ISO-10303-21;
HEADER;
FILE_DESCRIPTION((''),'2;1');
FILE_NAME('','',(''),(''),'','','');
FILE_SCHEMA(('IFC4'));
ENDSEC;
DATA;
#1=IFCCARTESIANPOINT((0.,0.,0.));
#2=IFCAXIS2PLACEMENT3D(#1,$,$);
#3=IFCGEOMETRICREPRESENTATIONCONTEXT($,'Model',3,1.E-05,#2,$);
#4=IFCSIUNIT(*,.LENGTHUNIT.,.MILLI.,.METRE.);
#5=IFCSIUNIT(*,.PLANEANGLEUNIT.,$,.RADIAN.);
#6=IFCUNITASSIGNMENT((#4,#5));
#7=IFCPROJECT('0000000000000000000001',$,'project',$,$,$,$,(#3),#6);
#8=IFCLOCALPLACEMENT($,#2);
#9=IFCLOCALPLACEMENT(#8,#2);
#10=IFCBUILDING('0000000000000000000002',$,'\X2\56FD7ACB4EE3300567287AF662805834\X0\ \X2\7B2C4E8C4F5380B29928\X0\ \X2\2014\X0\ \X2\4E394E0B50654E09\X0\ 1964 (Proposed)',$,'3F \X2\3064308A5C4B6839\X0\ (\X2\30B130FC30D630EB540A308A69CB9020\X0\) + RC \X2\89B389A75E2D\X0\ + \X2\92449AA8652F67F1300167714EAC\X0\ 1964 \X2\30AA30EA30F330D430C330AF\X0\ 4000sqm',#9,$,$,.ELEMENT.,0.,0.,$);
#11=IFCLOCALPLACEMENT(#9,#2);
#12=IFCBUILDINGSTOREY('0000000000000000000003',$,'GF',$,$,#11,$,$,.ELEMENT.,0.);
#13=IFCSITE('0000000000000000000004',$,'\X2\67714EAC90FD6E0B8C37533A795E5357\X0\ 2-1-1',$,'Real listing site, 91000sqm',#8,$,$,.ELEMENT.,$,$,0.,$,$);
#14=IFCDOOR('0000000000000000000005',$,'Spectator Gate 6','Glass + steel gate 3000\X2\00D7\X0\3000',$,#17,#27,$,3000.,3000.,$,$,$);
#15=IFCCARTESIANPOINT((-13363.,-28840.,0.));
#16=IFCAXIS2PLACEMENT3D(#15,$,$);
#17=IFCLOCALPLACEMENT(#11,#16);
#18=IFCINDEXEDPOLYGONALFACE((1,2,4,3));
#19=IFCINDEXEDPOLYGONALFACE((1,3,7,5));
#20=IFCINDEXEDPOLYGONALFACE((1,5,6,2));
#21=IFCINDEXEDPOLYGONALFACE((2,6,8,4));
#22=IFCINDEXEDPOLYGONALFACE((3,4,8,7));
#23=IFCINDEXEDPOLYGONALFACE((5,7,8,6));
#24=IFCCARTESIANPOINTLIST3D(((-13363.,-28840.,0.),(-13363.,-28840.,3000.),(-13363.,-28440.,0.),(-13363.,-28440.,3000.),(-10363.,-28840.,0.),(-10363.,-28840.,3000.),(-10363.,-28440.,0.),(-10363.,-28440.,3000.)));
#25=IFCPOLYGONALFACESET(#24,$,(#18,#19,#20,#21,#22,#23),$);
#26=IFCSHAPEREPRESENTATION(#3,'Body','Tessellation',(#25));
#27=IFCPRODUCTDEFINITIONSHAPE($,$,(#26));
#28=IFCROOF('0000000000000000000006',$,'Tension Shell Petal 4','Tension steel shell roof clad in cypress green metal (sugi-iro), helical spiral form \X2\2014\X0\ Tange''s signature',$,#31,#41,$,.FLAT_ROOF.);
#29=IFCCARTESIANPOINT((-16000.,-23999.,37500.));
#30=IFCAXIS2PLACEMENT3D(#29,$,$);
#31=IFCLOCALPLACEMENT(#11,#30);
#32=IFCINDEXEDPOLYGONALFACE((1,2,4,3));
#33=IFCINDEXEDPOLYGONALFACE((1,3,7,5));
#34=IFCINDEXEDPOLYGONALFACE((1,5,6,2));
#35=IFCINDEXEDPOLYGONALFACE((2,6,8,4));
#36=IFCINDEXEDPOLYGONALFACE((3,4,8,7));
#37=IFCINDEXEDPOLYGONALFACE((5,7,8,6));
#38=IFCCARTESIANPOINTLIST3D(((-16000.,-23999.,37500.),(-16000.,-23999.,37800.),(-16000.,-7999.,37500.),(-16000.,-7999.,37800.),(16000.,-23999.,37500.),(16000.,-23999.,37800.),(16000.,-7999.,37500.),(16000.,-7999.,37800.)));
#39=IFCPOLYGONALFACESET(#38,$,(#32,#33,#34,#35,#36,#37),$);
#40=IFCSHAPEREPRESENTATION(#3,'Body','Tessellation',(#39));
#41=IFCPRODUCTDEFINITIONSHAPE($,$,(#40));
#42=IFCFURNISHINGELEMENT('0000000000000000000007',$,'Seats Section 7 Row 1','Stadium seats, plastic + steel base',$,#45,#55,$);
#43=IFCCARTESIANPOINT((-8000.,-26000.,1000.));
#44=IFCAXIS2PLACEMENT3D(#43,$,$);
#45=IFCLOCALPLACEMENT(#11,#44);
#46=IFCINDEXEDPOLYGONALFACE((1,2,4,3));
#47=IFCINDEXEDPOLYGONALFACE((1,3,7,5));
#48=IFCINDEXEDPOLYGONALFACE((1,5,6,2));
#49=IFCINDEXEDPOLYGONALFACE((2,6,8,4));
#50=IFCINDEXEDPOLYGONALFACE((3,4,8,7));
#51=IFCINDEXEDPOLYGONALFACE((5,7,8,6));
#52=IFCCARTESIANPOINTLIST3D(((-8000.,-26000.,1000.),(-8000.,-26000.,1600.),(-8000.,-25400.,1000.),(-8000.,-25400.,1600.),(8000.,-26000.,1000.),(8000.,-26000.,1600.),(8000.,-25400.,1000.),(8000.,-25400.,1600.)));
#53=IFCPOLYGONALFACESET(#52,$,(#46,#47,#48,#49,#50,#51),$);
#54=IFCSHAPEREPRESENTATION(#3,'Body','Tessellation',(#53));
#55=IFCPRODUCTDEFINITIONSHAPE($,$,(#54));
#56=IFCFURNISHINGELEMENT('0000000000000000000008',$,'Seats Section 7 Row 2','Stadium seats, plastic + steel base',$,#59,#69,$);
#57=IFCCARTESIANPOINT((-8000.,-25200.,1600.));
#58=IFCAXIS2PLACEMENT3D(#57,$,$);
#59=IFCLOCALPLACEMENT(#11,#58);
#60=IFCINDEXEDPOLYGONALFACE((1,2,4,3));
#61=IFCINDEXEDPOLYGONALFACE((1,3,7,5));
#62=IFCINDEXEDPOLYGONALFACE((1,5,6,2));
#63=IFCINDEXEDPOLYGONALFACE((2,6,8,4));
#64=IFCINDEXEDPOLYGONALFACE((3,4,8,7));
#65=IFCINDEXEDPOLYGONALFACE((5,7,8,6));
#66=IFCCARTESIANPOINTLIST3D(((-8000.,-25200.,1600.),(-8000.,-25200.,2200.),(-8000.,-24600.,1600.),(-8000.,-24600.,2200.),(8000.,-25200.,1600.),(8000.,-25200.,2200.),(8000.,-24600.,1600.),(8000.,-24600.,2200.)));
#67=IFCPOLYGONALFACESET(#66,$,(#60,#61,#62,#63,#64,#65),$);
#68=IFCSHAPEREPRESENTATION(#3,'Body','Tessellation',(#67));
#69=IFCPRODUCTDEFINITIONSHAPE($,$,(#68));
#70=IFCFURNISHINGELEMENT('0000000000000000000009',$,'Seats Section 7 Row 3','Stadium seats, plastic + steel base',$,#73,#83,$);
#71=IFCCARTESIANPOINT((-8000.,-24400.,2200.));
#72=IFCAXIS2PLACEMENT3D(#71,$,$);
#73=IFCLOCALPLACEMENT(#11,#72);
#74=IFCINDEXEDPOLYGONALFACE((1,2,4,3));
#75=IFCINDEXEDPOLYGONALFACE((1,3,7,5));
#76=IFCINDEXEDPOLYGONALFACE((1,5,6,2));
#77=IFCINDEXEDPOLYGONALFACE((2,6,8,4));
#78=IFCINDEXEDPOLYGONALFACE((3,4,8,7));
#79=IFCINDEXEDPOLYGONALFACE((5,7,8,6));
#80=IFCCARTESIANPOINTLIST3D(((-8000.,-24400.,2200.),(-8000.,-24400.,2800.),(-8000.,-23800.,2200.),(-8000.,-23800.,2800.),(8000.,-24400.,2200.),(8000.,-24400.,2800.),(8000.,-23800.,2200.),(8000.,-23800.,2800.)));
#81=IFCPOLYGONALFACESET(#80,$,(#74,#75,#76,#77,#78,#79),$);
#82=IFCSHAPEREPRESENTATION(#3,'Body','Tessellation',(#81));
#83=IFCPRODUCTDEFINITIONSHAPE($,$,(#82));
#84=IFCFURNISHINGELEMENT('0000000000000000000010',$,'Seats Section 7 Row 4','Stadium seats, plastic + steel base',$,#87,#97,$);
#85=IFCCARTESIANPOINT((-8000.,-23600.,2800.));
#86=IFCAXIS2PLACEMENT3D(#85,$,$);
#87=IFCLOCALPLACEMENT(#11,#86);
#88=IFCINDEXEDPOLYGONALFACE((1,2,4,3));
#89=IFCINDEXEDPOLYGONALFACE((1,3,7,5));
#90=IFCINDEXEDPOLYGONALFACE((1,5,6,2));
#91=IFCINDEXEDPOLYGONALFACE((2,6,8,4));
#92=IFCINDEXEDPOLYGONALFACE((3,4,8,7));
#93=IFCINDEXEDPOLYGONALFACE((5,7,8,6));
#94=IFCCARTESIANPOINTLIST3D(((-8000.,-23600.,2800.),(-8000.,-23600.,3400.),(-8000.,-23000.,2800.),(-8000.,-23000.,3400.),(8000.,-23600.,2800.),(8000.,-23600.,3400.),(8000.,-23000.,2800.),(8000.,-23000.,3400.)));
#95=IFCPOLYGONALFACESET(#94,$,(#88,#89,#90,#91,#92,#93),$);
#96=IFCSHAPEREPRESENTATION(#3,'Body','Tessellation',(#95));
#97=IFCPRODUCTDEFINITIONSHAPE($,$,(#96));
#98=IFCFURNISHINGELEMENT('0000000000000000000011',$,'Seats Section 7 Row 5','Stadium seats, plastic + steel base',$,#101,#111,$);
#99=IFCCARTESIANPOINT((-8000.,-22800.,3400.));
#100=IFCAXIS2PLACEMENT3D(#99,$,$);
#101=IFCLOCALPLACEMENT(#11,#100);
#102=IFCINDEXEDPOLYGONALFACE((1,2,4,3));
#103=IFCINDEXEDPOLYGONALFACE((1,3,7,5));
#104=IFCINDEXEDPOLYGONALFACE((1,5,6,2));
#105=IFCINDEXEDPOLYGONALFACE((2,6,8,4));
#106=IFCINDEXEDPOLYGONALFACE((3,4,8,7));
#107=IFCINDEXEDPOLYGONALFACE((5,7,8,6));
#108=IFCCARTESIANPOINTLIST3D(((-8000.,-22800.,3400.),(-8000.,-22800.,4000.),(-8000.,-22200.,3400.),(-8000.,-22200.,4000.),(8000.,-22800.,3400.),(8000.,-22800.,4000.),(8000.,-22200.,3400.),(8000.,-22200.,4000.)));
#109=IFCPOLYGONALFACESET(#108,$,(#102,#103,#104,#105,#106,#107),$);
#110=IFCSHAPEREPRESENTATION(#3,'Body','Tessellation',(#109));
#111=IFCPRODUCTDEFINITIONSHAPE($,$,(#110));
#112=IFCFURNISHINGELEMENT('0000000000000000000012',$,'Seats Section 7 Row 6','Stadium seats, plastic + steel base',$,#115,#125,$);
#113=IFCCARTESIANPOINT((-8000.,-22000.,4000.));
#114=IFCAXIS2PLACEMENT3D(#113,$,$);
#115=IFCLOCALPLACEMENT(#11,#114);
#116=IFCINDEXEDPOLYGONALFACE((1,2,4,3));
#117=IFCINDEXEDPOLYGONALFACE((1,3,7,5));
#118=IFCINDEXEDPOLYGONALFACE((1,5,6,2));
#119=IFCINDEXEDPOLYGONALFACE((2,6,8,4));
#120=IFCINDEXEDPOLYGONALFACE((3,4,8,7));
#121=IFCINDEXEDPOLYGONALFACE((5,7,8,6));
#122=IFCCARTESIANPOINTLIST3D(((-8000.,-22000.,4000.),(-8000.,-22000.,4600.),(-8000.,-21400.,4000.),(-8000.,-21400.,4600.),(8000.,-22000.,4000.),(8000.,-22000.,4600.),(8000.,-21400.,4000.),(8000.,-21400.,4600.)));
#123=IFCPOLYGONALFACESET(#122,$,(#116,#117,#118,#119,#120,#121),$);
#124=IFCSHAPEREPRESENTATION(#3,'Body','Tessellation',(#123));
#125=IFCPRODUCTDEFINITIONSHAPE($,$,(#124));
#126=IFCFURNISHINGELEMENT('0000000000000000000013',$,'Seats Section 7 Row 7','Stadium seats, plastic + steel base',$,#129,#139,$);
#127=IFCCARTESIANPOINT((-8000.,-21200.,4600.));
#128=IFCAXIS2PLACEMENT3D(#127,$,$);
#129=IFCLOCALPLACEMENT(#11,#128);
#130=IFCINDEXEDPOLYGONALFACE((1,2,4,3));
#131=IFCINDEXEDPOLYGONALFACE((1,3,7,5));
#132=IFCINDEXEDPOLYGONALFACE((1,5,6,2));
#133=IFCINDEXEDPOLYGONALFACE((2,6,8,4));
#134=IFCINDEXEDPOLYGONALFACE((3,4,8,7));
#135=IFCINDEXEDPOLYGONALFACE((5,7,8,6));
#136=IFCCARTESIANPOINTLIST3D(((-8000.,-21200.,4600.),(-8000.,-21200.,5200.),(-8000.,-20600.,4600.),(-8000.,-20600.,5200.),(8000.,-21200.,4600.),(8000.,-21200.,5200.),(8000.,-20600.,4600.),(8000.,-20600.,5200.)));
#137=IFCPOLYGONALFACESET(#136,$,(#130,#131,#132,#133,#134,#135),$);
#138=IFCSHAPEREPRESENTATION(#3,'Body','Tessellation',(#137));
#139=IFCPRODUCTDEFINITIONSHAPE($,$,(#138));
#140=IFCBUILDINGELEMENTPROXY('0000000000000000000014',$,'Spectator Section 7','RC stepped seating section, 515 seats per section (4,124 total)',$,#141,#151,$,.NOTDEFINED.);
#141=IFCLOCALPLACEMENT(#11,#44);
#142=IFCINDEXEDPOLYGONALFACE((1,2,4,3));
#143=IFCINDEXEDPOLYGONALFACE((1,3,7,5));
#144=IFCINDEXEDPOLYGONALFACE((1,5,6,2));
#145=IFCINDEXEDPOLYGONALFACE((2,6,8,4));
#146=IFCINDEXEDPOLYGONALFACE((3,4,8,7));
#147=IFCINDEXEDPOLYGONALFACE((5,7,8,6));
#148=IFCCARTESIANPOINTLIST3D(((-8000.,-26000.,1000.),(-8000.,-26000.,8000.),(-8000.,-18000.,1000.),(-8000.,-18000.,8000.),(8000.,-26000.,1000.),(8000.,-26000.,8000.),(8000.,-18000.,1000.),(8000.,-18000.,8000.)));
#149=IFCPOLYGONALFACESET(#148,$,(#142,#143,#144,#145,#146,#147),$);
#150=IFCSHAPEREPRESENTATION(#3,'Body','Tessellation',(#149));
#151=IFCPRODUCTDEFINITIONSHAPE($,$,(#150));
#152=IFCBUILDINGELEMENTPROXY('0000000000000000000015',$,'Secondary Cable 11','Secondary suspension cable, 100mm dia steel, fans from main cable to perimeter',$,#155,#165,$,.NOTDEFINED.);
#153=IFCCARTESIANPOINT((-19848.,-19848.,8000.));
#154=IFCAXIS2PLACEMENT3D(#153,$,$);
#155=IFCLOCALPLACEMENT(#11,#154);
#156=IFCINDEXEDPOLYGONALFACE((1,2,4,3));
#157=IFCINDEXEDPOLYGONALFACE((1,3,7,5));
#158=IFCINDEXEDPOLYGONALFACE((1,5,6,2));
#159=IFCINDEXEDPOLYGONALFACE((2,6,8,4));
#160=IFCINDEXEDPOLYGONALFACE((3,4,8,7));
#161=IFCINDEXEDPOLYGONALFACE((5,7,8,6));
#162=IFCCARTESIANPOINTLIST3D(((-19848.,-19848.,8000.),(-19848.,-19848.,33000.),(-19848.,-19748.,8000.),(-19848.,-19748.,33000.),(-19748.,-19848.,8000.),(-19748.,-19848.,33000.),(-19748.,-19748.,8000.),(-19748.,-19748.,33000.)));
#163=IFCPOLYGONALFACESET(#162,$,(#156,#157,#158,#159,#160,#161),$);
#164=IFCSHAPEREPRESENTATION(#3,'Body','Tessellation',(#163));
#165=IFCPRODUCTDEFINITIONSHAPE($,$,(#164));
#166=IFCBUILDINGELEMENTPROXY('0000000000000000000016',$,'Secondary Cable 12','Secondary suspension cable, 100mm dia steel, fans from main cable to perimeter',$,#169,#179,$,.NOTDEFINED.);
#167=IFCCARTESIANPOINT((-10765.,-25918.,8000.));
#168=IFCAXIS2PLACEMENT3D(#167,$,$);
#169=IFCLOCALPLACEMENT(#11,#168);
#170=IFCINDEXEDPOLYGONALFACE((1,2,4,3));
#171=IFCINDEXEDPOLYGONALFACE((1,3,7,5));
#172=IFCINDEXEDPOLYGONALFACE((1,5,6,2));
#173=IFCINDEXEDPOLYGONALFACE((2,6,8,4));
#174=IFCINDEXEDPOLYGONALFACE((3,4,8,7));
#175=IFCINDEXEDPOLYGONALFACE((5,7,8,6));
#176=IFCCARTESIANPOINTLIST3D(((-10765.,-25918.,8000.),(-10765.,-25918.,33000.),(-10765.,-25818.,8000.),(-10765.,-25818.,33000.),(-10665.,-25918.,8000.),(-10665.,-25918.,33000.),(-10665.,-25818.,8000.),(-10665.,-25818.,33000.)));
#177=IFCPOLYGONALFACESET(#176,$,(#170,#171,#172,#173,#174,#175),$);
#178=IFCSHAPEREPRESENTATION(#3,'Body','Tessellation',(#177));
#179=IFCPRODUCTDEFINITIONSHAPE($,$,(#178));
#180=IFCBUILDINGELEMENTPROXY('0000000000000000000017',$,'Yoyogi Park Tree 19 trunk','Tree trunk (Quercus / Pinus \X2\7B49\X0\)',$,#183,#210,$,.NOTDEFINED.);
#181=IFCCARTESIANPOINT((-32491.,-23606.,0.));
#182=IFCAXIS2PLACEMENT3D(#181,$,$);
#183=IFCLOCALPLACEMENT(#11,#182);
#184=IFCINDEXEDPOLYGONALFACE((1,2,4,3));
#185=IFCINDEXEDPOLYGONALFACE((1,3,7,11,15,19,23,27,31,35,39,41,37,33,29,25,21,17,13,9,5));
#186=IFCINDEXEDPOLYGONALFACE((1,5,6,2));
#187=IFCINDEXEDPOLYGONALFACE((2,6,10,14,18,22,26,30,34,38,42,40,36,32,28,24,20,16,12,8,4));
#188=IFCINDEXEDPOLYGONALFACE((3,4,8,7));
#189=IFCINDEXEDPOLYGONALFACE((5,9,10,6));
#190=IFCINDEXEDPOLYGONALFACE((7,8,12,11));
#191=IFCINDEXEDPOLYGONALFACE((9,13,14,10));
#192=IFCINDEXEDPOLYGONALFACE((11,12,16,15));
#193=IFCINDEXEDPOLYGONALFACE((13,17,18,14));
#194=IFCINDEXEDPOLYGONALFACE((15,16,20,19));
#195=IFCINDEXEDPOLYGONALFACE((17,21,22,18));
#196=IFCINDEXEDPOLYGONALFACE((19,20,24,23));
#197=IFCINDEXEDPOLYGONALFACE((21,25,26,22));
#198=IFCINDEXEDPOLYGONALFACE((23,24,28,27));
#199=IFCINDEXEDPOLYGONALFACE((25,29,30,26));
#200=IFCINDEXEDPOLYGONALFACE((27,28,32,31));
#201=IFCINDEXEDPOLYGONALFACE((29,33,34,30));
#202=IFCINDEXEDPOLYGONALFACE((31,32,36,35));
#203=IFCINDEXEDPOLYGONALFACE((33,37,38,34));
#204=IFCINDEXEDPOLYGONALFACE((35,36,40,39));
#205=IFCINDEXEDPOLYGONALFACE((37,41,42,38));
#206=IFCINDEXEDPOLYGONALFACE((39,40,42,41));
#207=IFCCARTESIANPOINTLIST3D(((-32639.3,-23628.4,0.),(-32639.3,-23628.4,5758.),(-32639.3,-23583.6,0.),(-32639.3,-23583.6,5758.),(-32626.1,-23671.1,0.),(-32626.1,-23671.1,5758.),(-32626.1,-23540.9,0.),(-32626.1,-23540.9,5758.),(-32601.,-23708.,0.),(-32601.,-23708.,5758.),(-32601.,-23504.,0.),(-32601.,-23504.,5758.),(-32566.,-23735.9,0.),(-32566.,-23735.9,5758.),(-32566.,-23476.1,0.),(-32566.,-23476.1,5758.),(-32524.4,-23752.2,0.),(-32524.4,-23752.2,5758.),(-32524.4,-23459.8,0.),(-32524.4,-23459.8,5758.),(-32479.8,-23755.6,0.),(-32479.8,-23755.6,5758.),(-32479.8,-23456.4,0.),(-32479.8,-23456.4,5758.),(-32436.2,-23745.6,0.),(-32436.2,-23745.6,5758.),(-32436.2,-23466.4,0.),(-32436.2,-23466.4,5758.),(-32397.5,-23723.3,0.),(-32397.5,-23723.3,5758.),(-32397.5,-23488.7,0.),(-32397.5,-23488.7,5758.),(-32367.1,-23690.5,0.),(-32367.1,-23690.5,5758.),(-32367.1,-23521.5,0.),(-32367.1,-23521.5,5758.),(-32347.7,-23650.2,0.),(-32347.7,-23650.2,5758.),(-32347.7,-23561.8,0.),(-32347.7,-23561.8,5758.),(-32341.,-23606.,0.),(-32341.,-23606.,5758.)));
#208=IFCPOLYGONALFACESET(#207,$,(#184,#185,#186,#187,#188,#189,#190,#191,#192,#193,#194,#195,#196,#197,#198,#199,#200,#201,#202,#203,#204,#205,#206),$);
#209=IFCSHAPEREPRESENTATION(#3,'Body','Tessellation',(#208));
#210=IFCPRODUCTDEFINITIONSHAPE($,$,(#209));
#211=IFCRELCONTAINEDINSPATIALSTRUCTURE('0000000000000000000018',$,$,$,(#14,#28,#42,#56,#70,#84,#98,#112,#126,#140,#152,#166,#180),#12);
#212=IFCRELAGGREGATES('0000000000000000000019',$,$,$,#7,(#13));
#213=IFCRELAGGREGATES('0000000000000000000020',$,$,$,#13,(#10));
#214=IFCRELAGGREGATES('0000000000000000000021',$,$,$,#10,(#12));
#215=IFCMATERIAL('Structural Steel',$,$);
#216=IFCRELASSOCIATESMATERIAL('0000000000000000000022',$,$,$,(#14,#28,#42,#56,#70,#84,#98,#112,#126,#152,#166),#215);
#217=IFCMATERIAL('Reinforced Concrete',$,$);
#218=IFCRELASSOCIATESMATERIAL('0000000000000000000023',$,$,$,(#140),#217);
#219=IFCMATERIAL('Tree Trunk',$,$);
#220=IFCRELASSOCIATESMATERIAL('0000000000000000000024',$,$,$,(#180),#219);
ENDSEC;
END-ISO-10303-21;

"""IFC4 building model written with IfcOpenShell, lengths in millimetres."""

from ifc_helpers import new_model, si_unit, frame, frame_2d, origin, origin_2d, place, context, project, spatial, rectangle, circle, extrude, material, element, save


model = new_model("IFC4")

# Units and contexts
model_context = context("Model", 3, precision=1e-05, world=origin())
ifc_project = project(units=[si_unit("LENGTHUNIT", "METRE", prefix="MILLI"), si_unit("PLANEANGLEUNIT", "RADIAN")], contexts=[model_context])

# Site, building, storey
site_placement = place(None, origin())
site = spatial("IfcSite", under=ifc_project, at=site_placement, Name="東京都渋谷区神南 2-1-1", ObjectType="Real listing site, 91000sqm", CompositionType="ELEMENT", RefElevation=0.0)
building_placement = place(site_placement, origin())
building = spatial("IfcBuilding", under=site, at=building_placement, Name="国立代々木競技場 第二体育館 — 丹下健三 1964 (Proposed)", ObjectType="3F つり屋根 (ケーブル吊り構造) + RC 観覧席 + 鉄骨支柱、東京 1964 オリンピック 4000sqm", CompositionType="ELEMENT", ElevationOfRefHeight=0.0, ElevationOfTerrain=0.0)
storey_placement = place(building_placement, origin())
storey = spatial("IfcBuildingStorey", under=building, at=storey_placement, Name="GF", CompositionType="ELEMENT", Elevation=0.0)

# Shared definitions
ifc_material_1 = material(Name="Reinforced Concrete")

# Door
ifc_material_2 = material(Name="Structural Steel")
door_placement = place(storey_placement, frame((-13363.0, -28840.0, 0.0)))
element("IfcDoor", 1, at=door_placement, inside=storey, material=ifc_material_2, Name="Spectator Gate 6", Description="Glass + steel gate 3000×3000", OverallHeight=3000.0, OverallWidth=3000.0, context=model_context, shape_type="SweptSolid", body=[
    extrude(rectangle(XDim=3000.0, YDim=400.0, at=frame_2d((1500.0, 200.0))), frame((-13363.0, -28840.0, 0.0)), (0.0, 0.0, 1.0), 3000.0),
])

# Roof
roof_placement = place(storey_placement, frame((-16000.0, -23999.0, 37500.0)))
element("IfcRoof", 2, at=roof_placement, inside=storey, material=ifc_material_2, Name="Tension Shell Petal 4", Description="Tension steel shell roof clad in cypress green metal (sugi-iro), helical spiral form — Tange's signature", PredefinedType="FLAT_ROOF", context=model_context, shape_type="SweptSolid", body=[
    extrude(rectangle(XDim=32000.0, YDim=16000.0, at=frame_2d((16000.0, 8000.0))), frame((-16000.0, -23999.0, 37500.0)), (0.0, 0.0, 1.0), 300.0),
])

# Furnishing elements
furnishing_1_placement = place(storey_placement, frame((-8000.0, -26000.0, 1000.0)))
element("IfcFurnishingElement", 3, at=furnishing_1_placement, inside=storey, material=ifc_material_2, Name="Seats Section 7 Row 1", Description="Stadium seats, plastic + steel base", context=model_context, shape_type="SweptSolid", body=[
    extrude(rectangle(XDim=16000.0, YDim=600.0, at=frame_2d((8000.0, 300.0))), frame((-8000.0, -26000.0, 1000.0)), (0.0, 0.0, 1.0), 600.0),
])
furnishing_2_placement = place(storey_placement, frame((-8000.0, -25200.0, 1600.0)))
element("IfcFurnishingElement", 4, at=furnishing_2_placement, inside=storey, material=ifc_material_2, Name="Seats Section 7 Row 2", Description="Stadium seats, plastic + steel base", context=model_context, shape_type="SweptSolid", body=[
    extrude(rectangle(XDim=16000.0, YDim=600.0, at=frame_2d((8000.0, 300.0))), frame((-8000.0, -25200.0, 1600.0)), (0.0, 0.0, 1.0), 600.0),
])
furnishing_3_placement = place(storey_placement, frame((-8000.0, -24400.0, 2200.0)))
element("IfcFurnishingElement", 5, at=furnishing_3_placement, inside=storey, material=ifc_material_2, Name="Seats Section 7 Row 3", Description="Stadium seats, plastic + steel base", context=model_context, shape_type="SweptSolid", body=[
    extrude(rectangle(XDim=16000.0, YDim=600.0, at=frame_2d((8000.0, 300.0))), frame((-8000.0, -24400.0, 2200.0)), (0.0, 0.0, 1.0), 600.0),
])
furnishing_4_placement = place(storey_placement, frame((-8000.0, -23600.0, 2800.0)))
element("IfcFurnishingElement", 6, at=furnishing_4_placement, inside=storey, material=ifc_material_2, Name="Seats Section 7 Row 4", Description="Stadium seats, plastic + steel base", context=model_context, shape_type="SweptSolid", body=[
    extrude(rectangle(XDim=16000.0, YDim=600.0, at=frame_2d((8000.0, 300.0))), frame((-8000.0, -23600.0, 2800.0)), (0.0, 0.0, 1.0), 600.0),
])
furnishing_5_placement = place(storey_placement, frame((-8000.0, -22800.0, 3400.0)))
element("IfcFurnishingElement", 7, at=furnishing_5_placement, inside=storey, material=ifc_material_2, Name="Seats Section 7 Row 5", Description="Stadium seats, plastic + steel base", context=model_context, shape_type="SweptSolid", body=[
    extrude(rectangle(XDim=16000.0, YDim=600.0, at=frame_2d((8000.0, 300.0))), frame((-8000.0, -22800.0, 3400.0)), (0.0, 0.0, 1.0), 600.0),
])
furnishing_6_placement = place(storey_placement, frame((-8000.0, -22000.0, 4000.0)))
element("IfcFurnishingElement", 8, at=furnishing_6_placement, inside=storey, material=ifc_material_2, Name="Seats Section 7 Row 6", Description="Stadium seats, plastic + steel base", context=model_context, shape_type="SweptSolid", body=[
    extrude(rectangle(XDim=16000.0, YDim=600.0, at=frame_2d((8000.0, 300.0))), frame((-8000.0, -22000.0, 4000.0)), (0.0, 0.0, 1.0), 600.0),
])
furnishing_7_placement = place(storey_placement, frame((-8000.0, -21200.0, 4600.0)))
element("IfcFurnishingElement", 9, at=furnishing_7_placement, inside=storey, material=ifc_material_2, Name="Seats Section 7 Row 7", Description="Stadium seats, plastic + steel base", context=model_context, shape_type="SweptSolid", body=[
    extrude(rectangle(XDim=16000.0, YDim=600.0, at=frame_2d((8000.0, 300.0))), frame((-8000.0, -21200.0, 4600.0)), (0.0, 0.0, 1.0), 600.0),
])

# Building element proxies
proxy_1_placement = place(storey_placement, frame((-8000.0, -26000.0, 1000.0)))
element("IfcBuildingElementProxy", 10, at=proxy_1_placement, inside=storey, material=ifc_material_1, Name="Spectator Section 7", Description="RC stepped seating section, 515 seats per section (4,124 total)", PredefinedType="NOTDEFINED", context=model_context, shape_type="SweptSolid", body=[
    extrude(rectangle(XDim=16000.0, YDim=8000.0, at=frame_2d((8000.0, 4000.0))), frame((-8000.0, -26000.0, 1000.0)), (0.0, 0.0, 1.0), 7000.0),
])
proxy_2_placement = place(storey_placement, frame((-19848.0, -19848.0, 8000.0)))
element("IfcBuildingElementProxy", 11, at=proxy_2_placement, inside=storey, material=ifc_material_2, Name="Secondary Cable 11", Description="Secondary suspension cable, 100mm dia steel, fans from main cable to perimeter", PredefinedType="NOTDEFINED", context=model_context, shape_type="SweptSolid", body=[
    extrude(rectangle(XDim=100.0, YDim=100.0, at=frame_2d((50.0, 50.0))), frame((-19848.0, -19848.0, 8000.0)), (0.0, 0.0, 1.0), 25000.0),
])
proxy_3_placement = place(storey_placement, frame((-10765.0, -25918.0, 8000.0)))
element("IfcBuildingElementProxy", 12, at=proxy_3_placement, inside=storey, material=ifc_material_2, Name="Secondary Cable 12", Description="Secondary suspension cable, 100mm dia steel, fans from main cable to perimeter", PredefinedType="NOTDEFINED", context=model_context, shape_type="SweptSolid", body=[
    extrude(rectangle(XDim=100.0, YDim=100.0, at=frame_2d((50.0, 50.0))), frame((-10765.0, -25918.0, 8000.0)), (0.0, 0.0, 1.0), 25000.0),
])
ifc_material_3 = material(Name="Tree Trunk")
proxy_4_placement = place(storey_placement, frame((-32491.0, -23606.0, 0.0)))
element("IfcBuildingElementProxy", 13, at=proxy_4_placement, inside=storey, material=ifc_material_3, Name="Yoyogi Park Tree 19 trunk", Description="Tree trunk (Quercus / Pinus 等)", PredefinedType="NOTDEFINED", context=model_context, shape_type="SweptSolid", body=[
    extrude(circle(Radius=150.0, at=origin_2d()), frame((-32491.0, -23606.0, 0.0)), (0.0, 0.0, 1.0), 5758.0),
])

save(model, "model.ifc")
